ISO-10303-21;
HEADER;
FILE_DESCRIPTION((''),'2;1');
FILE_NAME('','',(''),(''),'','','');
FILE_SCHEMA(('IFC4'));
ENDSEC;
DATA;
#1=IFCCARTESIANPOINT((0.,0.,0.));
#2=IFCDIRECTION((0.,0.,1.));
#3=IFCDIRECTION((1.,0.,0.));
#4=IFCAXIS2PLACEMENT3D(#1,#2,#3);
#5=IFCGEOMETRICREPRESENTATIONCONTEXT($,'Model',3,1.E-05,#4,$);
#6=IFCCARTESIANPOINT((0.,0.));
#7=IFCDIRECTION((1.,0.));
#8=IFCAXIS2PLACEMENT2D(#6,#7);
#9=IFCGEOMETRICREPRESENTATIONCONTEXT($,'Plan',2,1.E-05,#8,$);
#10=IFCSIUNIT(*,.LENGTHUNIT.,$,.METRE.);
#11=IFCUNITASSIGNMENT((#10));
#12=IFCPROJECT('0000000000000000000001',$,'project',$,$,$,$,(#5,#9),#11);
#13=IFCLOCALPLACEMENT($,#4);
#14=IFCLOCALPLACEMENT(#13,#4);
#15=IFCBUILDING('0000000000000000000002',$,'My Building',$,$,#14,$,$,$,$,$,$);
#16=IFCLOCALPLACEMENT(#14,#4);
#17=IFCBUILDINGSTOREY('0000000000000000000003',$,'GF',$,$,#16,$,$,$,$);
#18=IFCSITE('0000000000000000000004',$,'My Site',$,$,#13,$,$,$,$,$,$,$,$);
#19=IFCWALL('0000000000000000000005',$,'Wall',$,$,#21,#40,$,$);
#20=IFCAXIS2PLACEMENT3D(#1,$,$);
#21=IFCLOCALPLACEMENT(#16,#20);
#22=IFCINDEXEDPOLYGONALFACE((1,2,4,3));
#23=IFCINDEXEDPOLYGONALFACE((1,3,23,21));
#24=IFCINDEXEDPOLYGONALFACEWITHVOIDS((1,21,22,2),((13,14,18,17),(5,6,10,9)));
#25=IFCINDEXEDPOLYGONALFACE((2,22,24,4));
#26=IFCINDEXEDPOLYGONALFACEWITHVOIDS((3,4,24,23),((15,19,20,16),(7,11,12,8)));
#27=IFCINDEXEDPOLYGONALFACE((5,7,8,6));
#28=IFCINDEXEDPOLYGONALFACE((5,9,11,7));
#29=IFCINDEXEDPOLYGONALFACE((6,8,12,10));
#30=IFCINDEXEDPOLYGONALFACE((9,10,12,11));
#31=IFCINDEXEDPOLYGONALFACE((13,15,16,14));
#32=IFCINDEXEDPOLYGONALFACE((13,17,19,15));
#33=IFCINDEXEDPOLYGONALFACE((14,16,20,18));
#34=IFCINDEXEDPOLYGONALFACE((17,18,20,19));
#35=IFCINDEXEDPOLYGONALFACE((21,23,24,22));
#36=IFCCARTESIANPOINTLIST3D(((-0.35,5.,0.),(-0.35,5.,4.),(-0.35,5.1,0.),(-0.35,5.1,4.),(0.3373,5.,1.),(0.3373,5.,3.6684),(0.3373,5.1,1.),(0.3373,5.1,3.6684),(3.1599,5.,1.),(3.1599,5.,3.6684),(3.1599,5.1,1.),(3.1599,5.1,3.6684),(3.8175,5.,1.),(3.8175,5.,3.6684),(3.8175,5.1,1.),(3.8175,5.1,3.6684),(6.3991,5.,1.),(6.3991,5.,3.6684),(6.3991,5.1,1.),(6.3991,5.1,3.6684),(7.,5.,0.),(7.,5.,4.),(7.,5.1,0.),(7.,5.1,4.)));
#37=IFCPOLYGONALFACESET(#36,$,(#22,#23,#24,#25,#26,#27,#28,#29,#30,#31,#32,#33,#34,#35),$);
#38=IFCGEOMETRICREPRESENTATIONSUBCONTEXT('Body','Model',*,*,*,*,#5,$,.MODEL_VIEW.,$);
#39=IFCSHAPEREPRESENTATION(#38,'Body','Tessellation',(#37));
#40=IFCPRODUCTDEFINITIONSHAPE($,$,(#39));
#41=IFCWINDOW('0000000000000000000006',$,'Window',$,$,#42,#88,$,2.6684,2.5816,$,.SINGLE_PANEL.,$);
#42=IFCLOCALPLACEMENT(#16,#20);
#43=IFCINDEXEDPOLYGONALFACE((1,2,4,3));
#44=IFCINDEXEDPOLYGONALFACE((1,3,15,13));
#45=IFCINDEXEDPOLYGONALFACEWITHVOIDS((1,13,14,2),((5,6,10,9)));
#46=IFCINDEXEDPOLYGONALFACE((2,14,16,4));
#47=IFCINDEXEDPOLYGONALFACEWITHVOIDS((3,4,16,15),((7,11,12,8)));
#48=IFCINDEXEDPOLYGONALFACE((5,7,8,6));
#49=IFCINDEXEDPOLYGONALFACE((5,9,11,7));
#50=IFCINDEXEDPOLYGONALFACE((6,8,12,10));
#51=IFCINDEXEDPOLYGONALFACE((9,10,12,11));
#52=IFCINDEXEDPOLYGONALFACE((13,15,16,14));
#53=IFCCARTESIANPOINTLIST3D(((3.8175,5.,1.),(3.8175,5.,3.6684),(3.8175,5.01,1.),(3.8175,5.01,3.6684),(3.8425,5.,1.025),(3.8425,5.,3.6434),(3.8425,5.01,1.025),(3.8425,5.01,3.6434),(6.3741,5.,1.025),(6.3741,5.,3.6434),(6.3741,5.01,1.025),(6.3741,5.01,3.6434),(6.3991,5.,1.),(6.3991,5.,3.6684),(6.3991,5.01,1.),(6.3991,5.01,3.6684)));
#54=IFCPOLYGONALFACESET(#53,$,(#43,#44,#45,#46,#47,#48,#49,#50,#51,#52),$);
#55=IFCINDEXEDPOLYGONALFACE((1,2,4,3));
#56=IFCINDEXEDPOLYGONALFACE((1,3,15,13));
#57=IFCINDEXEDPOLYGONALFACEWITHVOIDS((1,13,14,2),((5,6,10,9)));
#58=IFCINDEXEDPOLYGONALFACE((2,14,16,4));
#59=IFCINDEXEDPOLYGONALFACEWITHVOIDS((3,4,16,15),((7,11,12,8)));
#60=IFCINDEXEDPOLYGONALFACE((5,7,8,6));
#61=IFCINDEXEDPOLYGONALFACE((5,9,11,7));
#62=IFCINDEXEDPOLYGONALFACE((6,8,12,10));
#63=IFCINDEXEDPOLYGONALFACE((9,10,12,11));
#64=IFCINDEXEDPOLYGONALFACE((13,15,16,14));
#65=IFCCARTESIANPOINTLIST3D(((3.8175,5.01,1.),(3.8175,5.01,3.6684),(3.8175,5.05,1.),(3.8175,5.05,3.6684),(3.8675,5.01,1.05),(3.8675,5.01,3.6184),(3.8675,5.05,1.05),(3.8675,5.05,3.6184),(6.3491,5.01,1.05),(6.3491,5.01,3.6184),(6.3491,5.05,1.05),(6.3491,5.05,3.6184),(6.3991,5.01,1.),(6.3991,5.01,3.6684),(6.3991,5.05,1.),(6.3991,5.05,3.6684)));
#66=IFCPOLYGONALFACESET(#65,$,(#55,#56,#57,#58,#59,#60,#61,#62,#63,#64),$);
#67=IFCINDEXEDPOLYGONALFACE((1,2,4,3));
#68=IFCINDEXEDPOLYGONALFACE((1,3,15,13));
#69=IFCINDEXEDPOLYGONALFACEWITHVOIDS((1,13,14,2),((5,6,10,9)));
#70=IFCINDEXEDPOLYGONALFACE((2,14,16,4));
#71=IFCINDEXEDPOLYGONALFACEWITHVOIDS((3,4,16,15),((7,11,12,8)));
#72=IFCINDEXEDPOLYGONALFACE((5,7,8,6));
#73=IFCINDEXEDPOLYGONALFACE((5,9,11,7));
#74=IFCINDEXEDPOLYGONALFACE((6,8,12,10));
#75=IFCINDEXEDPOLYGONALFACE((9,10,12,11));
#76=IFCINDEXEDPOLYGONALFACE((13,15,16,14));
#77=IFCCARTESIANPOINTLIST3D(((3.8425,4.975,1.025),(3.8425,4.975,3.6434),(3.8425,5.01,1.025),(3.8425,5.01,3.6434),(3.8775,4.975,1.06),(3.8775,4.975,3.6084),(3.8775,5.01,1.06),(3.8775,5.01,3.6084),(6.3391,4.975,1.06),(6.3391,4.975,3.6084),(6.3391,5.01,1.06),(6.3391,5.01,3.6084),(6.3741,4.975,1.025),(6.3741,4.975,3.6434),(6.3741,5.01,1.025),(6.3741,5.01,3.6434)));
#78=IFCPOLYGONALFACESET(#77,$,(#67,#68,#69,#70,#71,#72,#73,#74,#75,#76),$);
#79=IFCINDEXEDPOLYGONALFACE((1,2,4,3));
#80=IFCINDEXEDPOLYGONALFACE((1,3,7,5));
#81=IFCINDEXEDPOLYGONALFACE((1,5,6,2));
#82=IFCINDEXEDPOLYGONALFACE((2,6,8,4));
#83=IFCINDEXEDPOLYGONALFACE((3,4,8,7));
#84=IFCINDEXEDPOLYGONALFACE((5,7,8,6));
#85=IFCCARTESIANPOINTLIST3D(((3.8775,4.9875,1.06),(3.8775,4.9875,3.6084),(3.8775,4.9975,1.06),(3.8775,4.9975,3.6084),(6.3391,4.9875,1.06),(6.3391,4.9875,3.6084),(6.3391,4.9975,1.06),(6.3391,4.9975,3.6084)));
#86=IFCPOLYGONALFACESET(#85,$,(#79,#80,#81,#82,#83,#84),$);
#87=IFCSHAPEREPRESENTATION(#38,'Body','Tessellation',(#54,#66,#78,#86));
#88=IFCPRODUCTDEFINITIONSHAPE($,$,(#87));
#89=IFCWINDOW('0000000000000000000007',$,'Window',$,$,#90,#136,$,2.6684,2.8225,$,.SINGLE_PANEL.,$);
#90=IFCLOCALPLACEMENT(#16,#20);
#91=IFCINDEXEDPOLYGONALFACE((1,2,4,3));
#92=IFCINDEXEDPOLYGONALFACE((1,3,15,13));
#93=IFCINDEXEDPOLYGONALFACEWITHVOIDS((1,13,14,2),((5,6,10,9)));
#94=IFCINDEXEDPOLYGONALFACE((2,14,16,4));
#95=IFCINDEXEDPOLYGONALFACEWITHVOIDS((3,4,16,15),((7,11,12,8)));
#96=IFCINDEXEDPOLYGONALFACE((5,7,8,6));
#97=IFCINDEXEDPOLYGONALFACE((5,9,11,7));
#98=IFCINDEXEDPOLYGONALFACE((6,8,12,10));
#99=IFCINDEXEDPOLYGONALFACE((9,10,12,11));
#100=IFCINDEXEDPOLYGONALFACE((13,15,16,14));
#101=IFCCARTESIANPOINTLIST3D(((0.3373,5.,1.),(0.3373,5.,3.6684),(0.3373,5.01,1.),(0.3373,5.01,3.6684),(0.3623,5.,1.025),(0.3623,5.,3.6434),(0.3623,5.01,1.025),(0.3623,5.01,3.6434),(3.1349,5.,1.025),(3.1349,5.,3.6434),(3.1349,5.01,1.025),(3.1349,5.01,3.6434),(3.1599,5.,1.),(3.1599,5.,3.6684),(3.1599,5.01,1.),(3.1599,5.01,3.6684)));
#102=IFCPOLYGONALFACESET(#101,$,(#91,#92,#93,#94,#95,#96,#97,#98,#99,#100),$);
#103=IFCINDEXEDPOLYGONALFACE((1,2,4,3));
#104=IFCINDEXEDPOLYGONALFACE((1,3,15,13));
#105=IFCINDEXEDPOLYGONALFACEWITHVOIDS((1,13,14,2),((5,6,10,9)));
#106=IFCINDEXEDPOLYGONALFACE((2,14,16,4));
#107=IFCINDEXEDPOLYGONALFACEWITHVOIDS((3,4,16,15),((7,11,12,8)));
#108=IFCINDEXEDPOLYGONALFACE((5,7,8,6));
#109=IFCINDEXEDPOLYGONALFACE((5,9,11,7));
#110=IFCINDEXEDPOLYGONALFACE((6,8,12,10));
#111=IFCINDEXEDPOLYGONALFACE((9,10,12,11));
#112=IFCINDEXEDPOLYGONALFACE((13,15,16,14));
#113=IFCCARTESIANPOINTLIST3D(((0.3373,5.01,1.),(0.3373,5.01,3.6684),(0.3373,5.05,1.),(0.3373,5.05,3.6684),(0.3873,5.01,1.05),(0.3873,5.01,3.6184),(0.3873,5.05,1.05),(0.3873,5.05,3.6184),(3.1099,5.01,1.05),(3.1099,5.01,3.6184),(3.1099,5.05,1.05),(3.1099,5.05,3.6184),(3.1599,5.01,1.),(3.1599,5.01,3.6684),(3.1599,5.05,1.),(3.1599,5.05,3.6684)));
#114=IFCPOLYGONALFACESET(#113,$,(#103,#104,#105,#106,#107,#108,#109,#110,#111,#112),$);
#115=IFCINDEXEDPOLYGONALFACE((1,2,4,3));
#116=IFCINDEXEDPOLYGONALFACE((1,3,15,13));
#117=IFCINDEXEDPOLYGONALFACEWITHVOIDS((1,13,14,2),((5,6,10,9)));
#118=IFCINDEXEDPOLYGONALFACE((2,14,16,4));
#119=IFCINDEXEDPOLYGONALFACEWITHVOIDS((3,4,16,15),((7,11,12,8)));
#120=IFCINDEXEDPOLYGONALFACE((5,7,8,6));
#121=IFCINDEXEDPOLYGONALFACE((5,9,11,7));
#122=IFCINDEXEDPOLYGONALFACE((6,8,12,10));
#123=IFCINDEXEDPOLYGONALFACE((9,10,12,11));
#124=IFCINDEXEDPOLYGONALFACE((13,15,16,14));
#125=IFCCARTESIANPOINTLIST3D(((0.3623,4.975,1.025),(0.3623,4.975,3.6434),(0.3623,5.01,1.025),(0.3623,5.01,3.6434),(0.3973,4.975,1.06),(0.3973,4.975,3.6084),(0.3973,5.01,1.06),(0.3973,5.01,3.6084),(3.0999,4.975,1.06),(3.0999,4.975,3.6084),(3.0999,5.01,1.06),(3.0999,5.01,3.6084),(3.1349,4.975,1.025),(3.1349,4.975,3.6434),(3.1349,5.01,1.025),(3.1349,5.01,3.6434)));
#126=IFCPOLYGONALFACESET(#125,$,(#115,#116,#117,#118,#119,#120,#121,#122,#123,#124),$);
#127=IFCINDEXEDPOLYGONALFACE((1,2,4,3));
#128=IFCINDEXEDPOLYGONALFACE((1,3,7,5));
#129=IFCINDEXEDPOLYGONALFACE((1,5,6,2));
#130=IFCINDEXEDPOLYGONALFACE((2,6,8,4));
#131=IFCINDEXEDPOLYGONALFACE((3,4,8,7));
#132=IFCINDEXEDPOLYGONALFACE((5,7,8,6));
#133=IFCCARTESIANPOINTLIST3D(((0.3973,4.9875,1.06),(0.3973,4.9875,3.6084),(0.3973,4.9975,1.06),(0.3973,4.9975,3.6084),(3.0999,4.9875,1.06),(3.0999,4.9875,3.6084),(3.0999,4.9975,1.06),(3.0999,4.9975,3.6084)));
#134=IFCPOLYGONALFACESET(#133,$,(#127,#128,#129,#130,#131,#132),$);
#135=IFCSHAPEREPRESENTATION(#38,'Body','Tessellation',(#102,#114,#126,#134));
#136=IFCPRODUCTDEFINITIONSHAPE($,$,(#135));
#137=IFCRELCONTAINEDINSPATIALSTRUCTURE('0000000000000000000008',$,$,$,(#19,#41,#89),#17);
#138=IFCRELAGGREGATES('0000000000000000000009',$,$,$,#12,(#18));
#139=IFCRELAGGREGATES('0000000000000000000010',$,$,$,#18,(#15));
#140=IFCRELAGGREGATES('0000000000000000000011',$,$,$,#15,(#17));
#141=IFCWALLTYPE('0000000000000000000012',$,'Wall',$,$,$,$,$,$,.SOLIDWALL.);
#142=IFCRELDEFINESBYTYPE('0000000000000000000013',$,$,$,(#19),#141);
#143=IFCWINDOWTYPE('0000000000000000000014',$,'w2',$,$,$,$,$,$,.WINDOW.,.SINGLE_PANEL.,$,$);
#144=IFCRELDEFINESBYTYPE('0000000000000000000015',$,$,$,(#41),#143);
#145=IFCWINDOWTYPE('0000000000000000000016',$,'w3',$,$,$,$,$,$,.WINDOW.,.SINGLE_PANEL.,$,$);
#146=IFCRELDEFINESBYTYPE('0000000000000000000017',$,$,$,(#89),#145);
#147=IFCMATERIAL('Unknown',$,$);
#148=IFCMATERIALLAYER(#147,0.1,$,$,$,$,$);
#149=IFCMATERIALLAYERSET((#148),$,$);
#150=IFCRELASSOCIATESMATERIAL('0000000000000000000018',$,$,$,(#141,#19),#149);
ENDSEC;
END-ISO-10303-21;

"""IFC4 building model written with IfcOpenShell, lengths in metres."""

from ifc_helpers import new_model, entity, si_unit, frame, origin_with_axes, origin_2d_with_axis, place, context, subcontext, project, spatial, line, indexed_curve, outline, extrude, shape, source, transform, mapped, material, layer, layer_set, layer_usage, type_object, type_shapes, element, fill, save


model = new_model("IFC4")

# Units and contexts
model_context = context("Model", 3, precision=1e-05, world=origin_with_axes())
plan_context = context("Plan", 2, precision=1e-05, world=origin_2d_with_axis())
body_context_1 = subcontext(model_context, "Body", "Model", "MODEL_VIEW")
body_context_2 = subcontext(plan_context, "Body", "Plan", "PLAN_VIEW")
ifc_project = project(units=[si_unit("LENGTHUNIT", "METRE")], contexts=[model_context, plan_context])

# Site, building, storey
site_placement = place(None, origin_with_axes())
site = spatial("IfcSite", under=ifc_project, at=site_placement, Name="My Site")
building_placement = place(site_placement, origin_with_axes())
building = spatial("IfcBuilding", under=site, at=building_placement, Name="My Building")
storey_placement = place(building_placement, origin_with_axes())
storey = spatial("IfcBuildingStorey", under=building, at=storey_placement, Name="GF")

# Shared definitions
ifc_material = material(Name="Unknown")

# Wall, openings, windows
ifc_layer_1 = layer(ifc_material, 0.1)
ifc_layer_set_1 = layer_set([ifc_layer_1])
wall_type = type_object("IfcWallType", Name="Wall", PredefinedType="SOLIDWALL", material=ifc_layer_set_1)
ifc_layer_usage_1 = layer_usage(ifc_layer_set_1, "AXIS2", "POSITIVE", 0.0)
wall_1_placement = place(storey_placement, frame((-0.35, 5.0, 0.0), z_axis=(0.0, 0.0, 1.0), x_axis=(1.0, 0.0, 0.0)))
wall_1 = element("IfcWall", 1, at=wall_1_placement, inside=storey, type_object=wall_type, material=ifc_layer_usage_1, Name="Wall", context=body_context_1, shape_type="SweptSolid", body=[
    extrude(outline(indexed_curve([(0.0, 0.0), (0.0, 0.1), (7.35, 0.1), (7.35, 0.0)], segments=[line(1, 2, 3, 4, 1)])), origin_with_axes(), (0.0, 0.0, 1.0), 4.0),
])
shared_shape_1 = source(origin_with_axes(), body_context_1, "Body", "SweptSolid", [
    extrude(outline(indexed_curve([(0.0, 0.0), (2.5816, 0.0), (2.5816, 2.6684), (0.0, 2.6684)], segments=[line(1, 2, 3, 4, 1)])), frame((0.0, -0.6, 0.0), z_axis=(0.0, -1.0, 0.0), x_axis=(1.0, 0.0, 0.0)), (0.0, 0.0, -1.0), 1.2),
])
opening_1_placement = place(wall_1_placement, frame((6.7491, 0.1, 1.0), z_axis=(0.0, 0.0, 1.0), x_axis=(-1.0, 0.0, 0.0)))
opening_1 = element("IfcOpeningElement", 2, at=opening_1_placement, cuts=wall_1, PredefinedType="OPENING", context=body_context_1, shape_type="MappedRepresentation", body=[
    mapped(shared_shape_1, transform((0.0, 0.0, 0.0), x_axis=(1.0, 0.0, 0.0), y_axis=(0.0, 1.0, 0.0), z_axis=(0.0, 0.0, 1.0), scale=1.0)),
])
shared_shape_2 = source(origin_with_axes(), body_context_1, "Body", "SweptSolid", [
    extrude(outline(indexed_curve([(0.0, 0.0), (2.8225, 0.0), (2.8225, 2.6684), (0.0, 2.6684)], segments=[line(1, 2, 3, 4, 1)])), frame((0.0, -0.6, 0.0), z_axis=(0.0, -1.0, 0.0), x_axis=(1.0, 0.0, 0.0)), (0.0, 0.0, -1.0), 1.2),
])
opening_2_placement = place(wall_1_placement, frame((3.5098, 0.1, 1.0), z_axis=(0.0, 0.0, 1.0), x_axis=(-1.0, 0.0, 0.0)))
opening_2 = element("IfcOpeningElement", 3, at=opening_2_placement, cuts=wall_1, PredefinedType="OPENING", context=body_context_1, shape_type="MappedRepresentation", body=[
    mapped(shared_shape_2, transform((0.0, 0.0, 0.0), x_axis=(1.0, 0.0, 0.0), y_axis=(0.0, 1.0, 0.0), z_axis=(0.0, 0.0, 1.0), scale=1.0)),
])
window_type_1 = type_object("IfcWindowType", Name="w2", PartitioningType="SINGLE_PANEL", PredefinedType="WINDOW")
shared_shape_3 = source(origin_with_axes(), body_context_1, "Body", "SweptSolid", [
    extrude(outline(indexed_curve([(0.0, 0.0), (2.5816, 0.0), (2.5816, 2.6684), (0.0, 2.6684)], segments=[line(1, 2, 3, 4, 1)]), holes=[indexed_curve([(0.025, 0.025), (2.5566, 0.025), (2.5566, 2.6434), (0.025, 2.6434)], segments=[line(1, 2, 3, 4, 1)])]), frame((0.0, 0.09, 0.0), z_axis=(0.0, -1.0, 0.0), x_axis=(1.0, 0.0, 0.0)), (0.0, 0.0, -1.0), 0.01),
    extrude(outline(indexed_curve([(0.0, 0.0), (2.5816, 0.0), (2.5816, 2.6684), (0.0, 2.6684)], segments=[line(1, 2, 3, 4, 1)]), holes=[indexed_curve([(0.05, 0.05), (2.5316, 0.05), (2.5316, 2.6184), (0.05, 2.6184)], segments=[line(1, 2, 3, 4, 1)])]), frame((0.0, 0.05, 0.0), z_axis=(0.0, -1.0, 0.0), x_axis=(1.0, 0.0, 0.0)), (0.0, 0.0, -1.0), 0.04),
    extrude(outline(indexed_curve([(0.0, 0.0), (2.5316, 0.0), (2.5316, 2.6184), (0.0, 2.6184)], segments=[line(1, 2, 3, 4, 1)]), holes=[indexed_curve([(0.035, 0.035), (2.4966, 0.035), (2.4966, 2.5834), (0.035, 2.5834)], segments=[line(1, 2, 3, 4, 1)])]), frame((0.025, 0.09, 0.025), z_axis=(0.0, -1.0, 0.0), x_axis=(1.0, 0.0, 0.0)), (0.0, 0.0, -1.0), 0.035),
    extrude(outline(indexed_curve([(0.035, 0.035), (2.4966, 0.035), (2.4966, 2.5834), (0.035, 2.5834)], segments=[line(1, 2, 3, 4, 1)])), frame((0.025, 0.1025, 0.025), z_axis=(0.0, -1.0, 0.0), x_axis=(1.0, 0.0, 0.0)), (0.0, 0.0, -1.0), 0.01),
])
shared_shape_4 = source(origin_with_axes(), body_context_2, "Body", "Curve2D", [
    entity("IfcIndexedPolyCurve", entity("IfcCartesianPointList2D", [[0.05, 0.05], [2.5316, 0.05]])),
    entity("IfcIndexedPolyCurve", entity("IfcCartesianPointList2D", [[0.0, 0.1], [0.025, 0.1], [0.025, 0.09], [0.05, 0.09], [0.05, 0.05], [0.0, 0.05]]), [entity("IfcLineIndex", [1, 2, 3, 4, 5, 6, 1])]),
    entity("IfcIndexedPolyCurve", entity("IfcCartesianPointList2D", [[2.5816, 0.1], [2.5566, 0.1], [2.5566, 0.09], [2.5316, 0.09], [2.5316, 0.05], [2.5816, 0.05]]), [entity("IfcLineIndex", [1, 2, 3, 4, 5, 6, 1])]),
    entity("IfcIndexedPolyCurve", entity("IfcCartesianPointList2D", [[0.025, 0.09], [0.06, 0.09], [0.06, 0.125], [0.025, 0.125]]), [entity("IfcLineIndex", [1, 2, 3, 4, 1])]),
    entity("IfcIndexedPolyCurve", entity("IfcCartesianPointList2D", [[2.5566, 0.09], [2.5216, 0.09], [2.5216, 0.125], [2.5566, 0.125]]), [entity("IfcLineIndex", [1, 2, 3, 4, 1])]),
    entity("IfcIndexedPolyCurve", entity("IfcCartesianPointList2D", [[0.06, 0.09], [2.5216, 0.09]])),
    entity("IfcIndexedPolyCurve", entity("IfcCartesianPointList2D", [[0.06, 0.125], [2.5216, 0.125]])),
    entity("IfcIndexedPolyCurve", entity("IfcCartesianPointList2D", [[0.06, 0.1075], [2.5216, 0.1075]])),
])
type_shapes(window_type_1, [shared_shape_3, shared_shape_4])
window_1_placement = place(opening_1_placement, frame((0.0, 0.0, 0.0), z_axis=(0.0, 0.0, 1.0), x_axis=(1.0, 0.0, 0.0)))
window_1 = element("IfcWindow", 4, at=window_1_placement, inside=storey, type_object=window_type_1, Name="Window", OverallHeight=2.6684, OverallWidth=2.5816, PartitioningType="SINGLE_PANEL", shapes=[
    shape(body_context_1, "Body", "MappedRepresentation", [mapped(shared_shape_3, transform((0.0, 0.0, 0.0), x_axis=(1.0, 0.0, 0.0), y_axis=(0.0, 1.0, 0.0), z_axis=(0.0, 0.0, 1.0), scale=1.0))]),
    shape(body_context_2, "Body", "MappedRepresentation", [mapped(shared_shape_4, transform((0.0, 0.0, 0.0), x_axis=(1.0, 0.0, 0.0), y_axis=(0.0, 1.0, 0.0), z_axis=(0.0, 0.0, 1.0), scale=1.0))]),
])
fill(opening_1, window_1)
window_type_2 = type_object("IfcWindowType", Name="w3", PartitioningType="SINGLE_PANEL", PredefinedType="WINDOW")
shared_shape_5 = source(origin_with_axes(), body_context_1, "Body", "SweptSolid", [
    extrude(outline(indexed_curve([(0.0, 0.0), (2.8225, 0.0), (2.8225, 2.6684), (0.0, 2.6684)], segments=[line(1, 2, 3, 4, 1)]), holes=[indexed_curve([(0.025, 0.025), (2.7975, 0.025), (2.7975, 2.6434), (0.025, 2.6434)], segments=[line(1, 2, 3, 4, 1)])]), frame((0.0, 0.09, 0.0), z_axis=(0.0, -1.0, 0.0), x_axis=(1.0, 0.0, 0.0)), (0.0, 0.0, -1.0), 0.01),
    extrude(outline(indexed_curve([(0.0, 0.0), (2.8225, 0.0), (2.8225, 2.6684), (0.0, 2.6684)], segments=[line(1, 2, 3, 4, 1)]), holes=[indexed_curve([(0.05, 0.05), (2.7725, 0.05), (2.7725, 2.6184), (0.05, 2.6184)], segments=[line(1, 2, 3, 4, 1)])]), frame((0.0, 0.05, 0.0), z_axis=(0.0, -1.0, 0.0), x_axis=(1.0, 0.0, 0.0)), (0.0, 0.0, -1.0), 0.04),
    extrude(outline(indexed_curve([(0.0, 0.0), (2.7725, 0.0), (2.7725, 2.6184), (0.0, 2.6184)], segments=[line(1, 2, 3, 4, 1)]), holes=[indexed_curve([(0.035, 0.035), (2.7375, 0.035), (2.7375, 2.5834), (0.035, 2.5834)], segments=[line(1, 2, 3, 4, 1)])]), frame((0.025, 0.09, 0.025), z_axis=(0.0, -1.0, 0.0), x_axis=(1.0, 0.0, 0.0)), (0.0, 0.0, -1.0), 0.035),
    extrude(outline(indexed_curve([(0.035, 0.035), (2.7375, 0.035), (2.7375, 2.5834), (0.035, 2.5834)], segments=[line(1, 2, 3, 4, 1)])), frame((0.025, 0.1025, 0.025), z_axis=(0.0, -1.0, 0.0), x_axis=(1.0, 0.0, 0.0)), (0.0, 0.0, -1.0), 0.01),
])
shared_shape_6 = source(origin_with_axes(), body_context_2, "Body", "Curve2D", [
    entity("IfcIndexedPolyCurve", entity("IfcCartesianPointList2D", [[0.05, 0.05], [2.7725, 0.05]])),
    entity("IfcIndexedPolyCurve", entity("IfcCartesianPointList2D", [[0.0, 0.1], [0.025, 0.1], [0.025, 0.09], [0.05, 0.09], [0.05, 0.05], [0.0, 0.05]]), [entity("IfcLineIndex", [1, 2, 3, 4, 5, 6, 1])]),
    entity("IfcIndexedPolyCurve", entity("IfcCartesianPointList2D", [[2.8225, 0.1], [2.7975, 0.1], [2.7975, 0.09], [2.7725, 0.09], [2.7725, 0.05], [2.8225, 0.05]]), [entity("IfcLineIndex", [1, 2, 3, 4, 5, 6, 1])]),
    entity("IfcIndexedPolyCurve", entity("IfcCartesianPointList2D", [[0.025, 0.09], [0.06, 0.09], [0.06, 0.125], [0.025, 0.125]]), [entity("IfcLineIndex", [1, 2, 3, 4, 1])]),
    entity("IfcIndexedPolyCurve", entity("IfcCartesianPointList2D", [[2.7975, 0.09], [2.7625, 0.09], [2.7625, 0.125], [2.7975, 0.125]]), [entity("IfcLineIndex", [1, 2, 3, 4, 1])]),
    entity("IfcIndexedPolyCurve", entity("IfcCartesianPointList2D", [[0.06, 0.09], [2.7625, 0.09]])),
    entity("IfcIndexedPolyCurve", entity("IfcCartesianPointList2D", [[0.06, 0.125], [2.7625, 0.125]])),
    entity("IfcIndexedPolyCurve", entity("IfcCartesianPointList2D", [[0.06, 0.1075], [2.7625, 0.1075]])),
])
type_shapes(window_type_2, [shared_shape_5, shared_shape_6])
window_2_placement = place(opening_2_placement, frame((0.0, 0.0, 0.0), z_axis=(0.0, 0.0, 1.0), x_axis=(1.0, 0.0, 0.0)))
window_2 = element("IfcWindow", 5, at=window_2_placement, inside=storey, type_object=window_type_2, Name="Window", OverallHeight=2.6684, OverallWidth=2.8225, PartitioningType="SINGLE_PANEL", shapes=[
    shape(body_context_1, "Body", "MappedRepresentation", [mapped(shared_shape_5, transform((0.0, 0.0, 0.0), x_axis=(1.0, 0.0, 0.0), y_axis=(0.0, 1.0, 0.0), z_axis=(0.0, 0.0, 1.0), scale=1.0))]),
    shape(body_context_2, "Body", "MappedRepresentation", [mapped(shared_shape_6, transform((0.0, 0.0, 0.0), x_axis=(1.0, 0.0, 0.0), y_axis=(0.0, 1.0, 0.0), z_axis=(0.0, 0.0, 1.0), scale=1.0))]),
])
fill(opening_2, window_2)

save(model, "model.ifc")
